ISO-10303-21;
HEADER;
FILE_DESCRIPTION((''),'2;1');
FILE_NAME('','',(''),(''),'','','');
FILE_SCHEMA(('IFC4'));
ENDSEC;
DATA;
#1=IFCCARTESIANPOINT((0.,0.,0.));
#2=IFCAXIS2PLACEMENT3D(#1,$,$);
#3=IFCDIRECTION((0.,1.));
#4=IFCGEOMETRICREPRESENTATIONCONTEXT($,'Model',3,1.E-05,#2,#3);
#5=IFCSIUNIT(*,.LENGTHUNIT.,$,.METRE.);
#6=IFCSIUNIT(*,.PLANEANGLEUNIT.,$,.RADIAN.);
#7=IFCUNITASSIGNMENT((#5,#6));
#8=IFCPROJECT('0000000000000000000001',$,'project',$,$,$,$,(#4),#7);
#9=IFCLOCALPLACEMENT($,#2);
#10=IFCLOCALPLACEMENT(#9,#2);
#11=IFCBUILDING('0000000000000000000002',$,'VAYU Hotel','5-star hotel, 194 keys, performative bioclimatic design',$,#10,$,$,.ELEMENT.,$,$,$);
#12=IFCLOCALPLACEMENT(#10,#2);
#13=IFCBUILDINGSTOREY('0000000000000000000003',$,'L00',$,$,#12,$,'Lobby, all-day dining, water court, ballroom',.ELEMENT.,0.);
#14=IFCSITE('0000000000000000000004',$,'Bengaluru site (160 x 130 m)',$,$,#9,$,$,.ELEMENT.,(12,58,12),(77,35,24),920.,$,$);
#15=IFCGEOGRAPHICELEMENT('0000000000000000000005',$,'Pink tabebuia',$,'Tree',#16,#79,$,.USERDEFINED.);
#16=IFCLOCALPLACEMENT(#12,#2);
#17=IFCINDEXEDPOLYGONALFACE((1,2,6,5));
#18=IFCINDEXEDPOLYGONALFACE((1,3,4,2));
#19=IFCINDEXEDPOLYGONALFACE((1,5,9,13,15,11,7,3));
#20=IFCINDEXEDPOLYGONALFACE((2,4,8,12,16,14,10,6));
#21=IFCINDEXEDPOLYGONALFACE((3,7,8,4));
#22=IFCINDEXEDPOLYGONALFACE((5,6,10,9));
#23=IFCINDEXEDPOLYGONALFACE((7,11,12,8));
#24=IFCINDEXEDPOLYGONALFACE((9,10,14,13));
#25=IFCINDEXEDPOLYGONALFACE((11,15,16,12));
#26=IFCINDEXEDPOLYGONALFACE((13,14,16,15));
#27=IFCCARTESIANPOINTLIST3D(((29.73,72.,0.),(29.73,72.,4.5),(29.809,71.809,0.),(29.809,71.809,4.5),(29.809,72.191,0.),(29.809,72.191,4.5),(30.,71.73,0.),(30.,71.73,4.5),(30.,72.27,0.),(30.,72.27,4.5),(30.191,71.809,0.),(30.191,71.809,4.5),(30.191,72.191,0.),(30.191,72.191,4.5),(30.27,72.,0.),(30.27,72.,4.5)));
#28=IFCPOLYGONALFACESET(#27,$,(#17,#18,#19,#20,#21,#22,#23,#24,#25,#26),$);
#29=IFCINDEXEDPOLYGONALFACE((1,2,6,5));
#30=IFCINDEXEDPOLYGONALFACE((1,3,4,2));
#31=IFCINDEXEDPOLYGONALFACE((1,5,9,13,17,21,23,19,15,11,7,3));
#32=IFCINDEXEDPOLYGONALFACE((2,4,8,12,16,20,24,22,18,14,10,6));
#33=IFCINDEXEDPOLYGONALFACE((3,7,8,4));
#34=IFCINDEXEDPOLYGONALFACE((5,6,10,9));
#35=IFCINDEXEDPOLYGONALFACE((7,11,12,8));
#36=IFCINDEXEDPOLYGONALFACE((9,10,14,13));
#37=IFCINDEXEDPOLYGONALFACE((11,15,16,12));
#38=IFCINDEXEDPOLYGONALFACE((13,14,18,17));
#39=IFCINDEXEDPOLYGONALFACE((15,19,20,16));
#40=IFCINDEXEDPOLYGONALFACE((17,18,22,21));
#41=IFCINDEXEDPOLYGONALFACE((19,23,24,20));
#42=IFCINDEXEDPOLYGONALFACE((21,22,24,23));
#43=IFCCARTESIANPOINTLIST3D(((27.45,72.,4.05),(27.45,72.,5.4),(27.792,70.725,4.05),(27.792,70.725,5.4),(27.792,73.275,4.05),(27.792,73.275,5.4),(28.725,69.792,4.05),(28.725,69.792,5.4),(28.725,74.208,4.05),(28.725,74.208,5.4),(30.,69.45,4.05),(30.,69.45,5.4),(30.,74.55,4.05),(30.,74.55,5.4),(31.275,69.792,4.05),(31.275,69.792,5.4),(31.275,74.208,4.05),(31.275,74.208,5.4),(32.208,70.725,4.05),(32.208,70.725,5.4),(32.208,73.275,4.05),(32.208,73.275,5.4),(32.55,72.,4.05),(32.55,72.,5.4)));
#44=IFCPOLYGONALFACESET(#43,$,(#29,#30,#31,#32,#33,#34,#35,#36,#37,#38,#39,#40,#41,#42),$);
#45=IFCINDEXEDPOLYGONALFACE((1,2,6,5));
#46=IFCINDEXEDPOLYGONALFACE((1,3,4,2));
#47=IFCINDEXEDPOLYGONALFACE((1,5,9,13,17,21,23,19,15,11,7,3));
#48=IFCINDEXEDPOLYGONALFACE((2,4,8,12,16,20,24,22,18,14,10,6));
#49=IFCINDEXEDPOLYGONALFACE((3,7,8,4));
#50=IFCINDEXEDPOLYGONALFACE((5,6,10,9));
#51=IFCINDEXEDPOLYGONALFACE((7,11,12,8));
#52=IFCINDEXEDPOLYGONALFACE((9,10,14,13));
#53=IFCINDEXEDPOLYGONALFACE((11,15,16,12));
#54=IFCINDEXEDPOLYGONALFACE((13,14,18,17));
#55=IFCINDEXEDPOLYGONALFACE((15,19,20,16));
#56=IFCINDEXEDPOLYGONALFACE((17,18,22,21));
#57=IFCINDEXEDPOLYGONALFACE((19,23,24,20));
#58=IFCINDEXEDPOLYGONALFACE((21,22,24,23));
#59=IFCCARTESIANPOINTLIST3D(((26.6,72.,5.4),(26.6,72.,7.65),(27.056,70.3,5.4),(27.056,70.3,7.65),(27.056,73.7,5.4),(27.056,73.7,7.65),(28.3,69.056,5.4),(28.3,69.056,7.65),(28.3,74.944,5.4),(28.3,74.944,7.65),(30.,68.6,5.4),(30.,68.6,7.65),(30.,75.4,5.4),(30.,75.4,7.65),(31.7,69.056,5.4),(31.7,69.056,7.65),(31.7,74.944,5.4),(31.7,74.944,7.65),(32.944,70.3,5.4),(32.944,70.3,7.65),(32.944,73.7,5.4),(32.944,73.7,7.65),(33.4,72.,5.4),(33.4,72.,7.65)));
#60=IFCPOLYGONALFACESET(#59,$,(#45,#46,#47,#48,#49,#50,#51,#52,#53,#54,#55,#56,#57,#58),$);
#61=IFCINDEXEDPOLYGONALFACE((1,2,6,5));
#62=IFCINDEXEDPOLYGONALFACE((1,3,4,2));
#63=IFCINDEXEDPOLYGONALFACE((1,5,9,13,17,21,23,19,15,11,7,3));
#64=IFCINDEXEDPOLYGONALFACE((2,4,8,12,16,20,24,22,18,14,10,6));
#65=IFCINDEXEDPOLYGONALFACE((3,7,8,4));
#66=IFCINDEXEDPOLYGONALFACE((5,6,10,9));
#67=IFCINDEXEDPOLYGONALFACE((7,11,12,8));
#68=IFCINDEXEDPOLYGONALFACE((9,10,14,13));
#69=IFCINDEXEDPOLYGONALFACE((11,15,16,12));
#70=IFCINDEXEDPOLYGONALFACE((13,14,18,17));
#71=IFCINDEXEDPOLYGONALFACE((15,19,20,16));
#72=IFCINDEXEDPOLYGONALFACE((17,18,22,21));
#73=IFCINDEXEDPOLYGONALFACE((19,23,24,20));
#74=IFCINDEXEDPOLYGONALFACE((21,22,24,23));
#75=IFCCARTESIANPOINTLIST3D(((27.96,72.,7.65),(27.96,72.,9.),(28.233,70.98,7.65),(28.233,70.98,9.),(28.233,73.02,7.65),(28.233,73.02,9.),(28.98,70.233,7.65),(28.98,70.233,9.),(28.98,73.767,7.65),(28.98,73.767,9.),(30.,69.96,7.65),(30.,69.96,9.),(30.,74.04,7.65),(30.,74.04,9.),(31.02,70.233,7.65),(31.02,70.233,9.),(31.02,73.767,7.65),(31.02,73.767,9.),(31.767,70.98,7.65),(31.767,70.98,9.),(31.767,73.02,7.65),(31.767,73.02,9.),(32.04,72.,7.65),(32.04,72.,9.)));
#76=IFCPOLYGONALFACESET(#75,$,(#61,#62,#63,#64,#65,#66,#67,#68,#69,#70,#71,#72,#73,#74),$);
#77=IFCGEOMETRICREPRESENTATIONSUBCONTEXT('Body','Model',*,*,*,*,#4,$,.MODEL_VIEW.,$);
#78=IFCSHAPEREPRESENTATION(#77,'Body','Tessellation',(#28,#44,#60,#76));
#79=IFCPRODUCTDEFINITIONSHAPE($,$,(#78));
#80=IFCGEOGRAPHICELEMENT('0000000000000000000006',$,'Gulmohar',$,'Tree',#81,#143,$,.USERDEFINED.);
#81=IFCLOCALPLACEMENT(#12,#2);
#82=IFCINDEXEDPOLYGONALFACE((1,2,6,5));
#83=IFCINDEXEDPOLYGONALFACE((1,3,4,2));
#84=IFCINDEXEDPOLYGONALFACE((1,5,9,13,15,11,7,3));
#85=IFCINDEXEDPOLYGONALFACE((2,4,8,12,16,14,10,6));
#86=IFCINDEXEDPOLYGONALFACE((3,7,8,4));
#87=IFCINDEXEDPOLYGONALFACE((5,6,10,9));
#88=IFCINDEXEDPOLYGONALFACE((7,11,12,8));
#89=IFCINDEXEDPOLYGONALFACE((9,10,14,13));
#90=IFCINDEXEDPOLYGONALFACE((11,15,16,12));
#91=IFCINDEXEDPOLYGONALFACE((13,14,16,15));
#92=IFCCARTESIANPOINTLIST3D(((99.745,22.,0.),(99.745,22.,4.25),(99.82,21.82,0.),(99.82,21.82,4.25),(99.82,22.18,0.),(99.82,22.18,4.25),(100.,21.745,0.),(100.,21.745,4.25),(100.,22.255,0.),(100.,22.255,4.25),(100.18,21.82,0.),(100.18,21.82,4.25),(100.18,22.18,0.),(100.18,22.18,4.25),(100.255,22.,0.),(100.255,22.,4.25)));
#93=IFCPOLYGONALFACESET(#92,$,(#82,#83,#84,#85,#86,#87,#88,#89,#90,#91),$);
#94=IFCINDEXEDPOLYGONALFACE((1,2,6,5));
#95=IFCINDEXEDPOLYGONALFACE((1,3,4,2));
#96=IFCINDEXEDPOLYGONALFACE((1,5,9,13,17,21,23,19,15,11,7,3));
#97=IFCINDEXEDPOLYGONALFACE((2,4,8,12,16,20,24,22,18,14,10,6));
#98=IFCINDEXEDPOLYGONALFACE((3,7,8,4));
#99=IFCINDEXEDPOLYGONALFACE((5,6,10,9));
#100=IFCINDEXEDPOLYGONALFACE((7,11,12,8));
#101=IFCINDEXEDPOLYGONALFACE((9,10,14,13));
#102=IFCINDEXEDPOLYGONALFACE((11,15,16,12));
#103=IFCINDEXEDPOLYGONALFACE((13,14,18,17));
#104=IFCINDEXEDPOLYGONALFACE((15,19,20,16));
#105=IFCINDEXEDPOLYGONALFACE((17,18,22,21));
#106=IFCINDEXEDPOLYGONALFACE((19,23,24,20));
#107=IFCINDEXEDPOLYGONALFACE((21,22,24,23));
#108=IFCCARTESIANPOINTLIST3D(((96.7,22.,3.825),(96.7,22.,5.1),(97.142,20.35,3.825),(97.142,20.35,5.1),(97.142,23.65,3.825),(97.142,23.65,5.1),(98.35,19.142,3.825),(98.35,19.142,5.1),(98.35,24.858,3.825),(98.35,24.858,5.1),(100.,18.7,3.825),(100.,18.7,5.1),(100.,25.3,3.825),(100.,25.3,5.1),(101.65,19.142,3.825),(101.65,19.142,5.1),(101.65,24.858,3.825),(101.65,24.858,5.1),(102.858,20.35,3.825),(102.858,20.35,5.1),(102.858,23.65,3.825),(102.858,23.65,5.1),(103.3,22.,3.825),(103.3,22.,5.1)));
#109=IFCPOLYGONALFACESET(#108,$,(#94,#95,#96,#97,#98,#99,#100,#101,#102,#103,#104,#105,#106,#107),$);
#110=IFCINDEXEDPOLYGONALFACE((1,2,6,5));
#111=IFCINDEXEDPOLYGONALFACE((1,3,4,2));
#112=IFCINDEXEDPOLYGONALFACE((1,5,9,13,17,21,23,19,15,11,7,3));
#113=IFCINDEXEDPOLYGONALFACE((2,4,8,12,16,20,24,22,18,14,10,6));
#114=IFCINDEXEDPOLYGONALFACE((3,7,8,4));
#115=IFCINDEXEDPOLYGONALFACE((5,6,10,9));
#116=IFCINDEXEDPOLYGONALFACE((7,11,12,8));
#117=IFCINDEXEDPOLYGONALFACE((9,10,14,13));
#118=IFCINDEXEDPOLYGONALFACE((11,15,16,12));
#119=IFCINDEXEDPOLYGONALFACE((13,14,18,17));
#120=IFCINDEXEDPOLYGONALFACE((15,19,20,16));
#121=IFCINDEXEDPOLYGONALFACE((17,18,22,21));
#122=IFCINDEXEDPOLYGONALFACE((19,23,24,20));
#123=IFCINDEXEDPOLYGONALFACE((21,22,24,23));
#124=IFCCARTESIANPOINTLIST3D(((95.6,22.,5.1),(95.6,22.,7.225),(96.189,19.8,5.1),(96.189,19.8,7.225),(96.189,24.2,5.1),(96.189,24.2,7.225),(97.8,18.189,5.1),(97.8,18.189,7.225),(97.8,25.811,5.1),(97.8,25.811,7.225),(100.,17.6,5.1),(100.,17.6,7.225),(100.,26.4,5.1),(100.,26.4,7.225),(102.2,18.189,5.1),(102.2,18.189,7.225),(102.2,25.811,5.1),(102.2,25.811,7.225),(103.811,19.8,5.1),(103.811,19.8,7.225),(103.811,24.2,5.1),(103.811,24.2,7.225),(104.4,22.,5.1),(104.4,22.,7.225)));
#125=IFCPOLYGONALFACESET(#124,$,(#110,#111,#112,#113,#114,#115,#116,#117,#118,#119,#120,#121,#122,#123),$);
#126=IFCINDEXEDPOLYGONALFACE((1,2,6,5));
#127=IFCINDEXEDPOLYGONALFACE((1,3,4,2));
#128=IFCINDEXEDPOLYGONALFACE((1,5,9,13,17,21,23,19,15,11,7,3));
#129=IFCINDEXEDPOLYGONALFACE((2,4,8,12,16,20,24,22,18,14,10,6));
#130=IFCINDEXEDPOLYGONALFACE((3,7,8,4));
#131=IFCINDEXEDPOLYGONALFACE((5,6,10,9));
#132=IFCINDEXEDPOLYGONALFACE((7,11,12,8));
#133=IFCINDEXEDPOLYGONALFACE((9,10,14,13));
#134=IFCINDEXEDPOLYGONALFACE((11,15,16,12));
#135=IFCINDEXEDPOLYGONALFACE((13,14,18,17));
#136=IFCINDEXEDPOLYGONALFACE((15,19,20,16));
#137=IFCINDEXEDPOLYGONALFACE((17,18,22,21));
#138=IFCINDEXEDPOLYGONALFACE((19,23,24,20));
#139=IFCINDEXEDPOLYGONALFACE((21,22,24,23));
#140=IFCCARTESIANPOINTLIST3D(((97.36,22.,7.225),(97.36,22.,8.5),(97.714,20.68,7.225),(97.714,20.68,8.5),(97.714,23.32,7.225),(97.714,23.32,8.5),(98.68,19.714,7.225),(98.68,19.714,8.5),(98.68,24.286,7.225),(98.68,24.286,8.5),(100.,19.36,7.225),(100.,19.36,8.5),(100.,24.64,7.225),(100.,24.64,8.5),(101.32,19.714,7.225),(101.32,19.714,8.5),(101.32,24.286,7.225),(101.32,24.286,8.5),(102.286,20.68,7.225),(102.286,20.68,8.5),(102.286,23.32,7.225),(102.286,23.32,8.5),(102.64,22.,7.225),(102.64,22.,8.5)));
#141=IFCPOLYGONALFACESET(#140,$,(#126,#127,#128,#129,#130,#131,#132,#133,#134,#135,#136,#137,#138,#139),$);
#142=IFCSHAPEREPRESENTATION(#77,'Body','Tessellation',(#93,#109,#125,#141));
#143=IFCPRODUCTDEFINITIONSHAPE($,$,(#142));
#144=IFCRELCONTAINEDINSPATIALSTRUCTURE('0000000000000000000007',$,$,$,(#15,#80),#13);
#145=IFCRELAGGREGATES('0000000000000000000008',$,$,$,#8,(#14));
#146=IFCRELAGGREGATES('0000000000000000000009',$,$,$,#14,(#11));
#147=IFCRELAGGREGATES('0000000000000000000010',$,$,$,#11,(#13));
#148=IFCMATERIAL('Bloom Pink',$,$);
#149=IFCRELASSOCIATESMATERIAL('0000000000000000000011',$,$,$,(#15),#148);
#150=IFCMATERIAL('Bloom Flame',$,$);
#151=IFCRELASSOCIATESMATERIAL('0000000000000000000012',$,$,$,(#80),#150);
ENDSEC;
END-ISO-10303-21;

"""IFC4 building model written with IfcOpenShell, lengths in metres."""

from ifc_helpers import new_model, si_unit, direction, frame, origin, place, context, subcontext, project, spatial, polyline, outline, extrude, material, element, save


model = new_model("IFC4")

# Units and contexts
model_context = context("Model", 3, precision=1e-05, world=origin(), true_north=direction((0.0, 1.0)))
body_context = subcontext(model_context, "Body", "Model", "MODEL_VIEW")
ifc_project = project(units=[si_unit("LENGTHUNIT", "METRE"), si_unit("PLANEANGLEUNIT", "RADIAN")], contexts=[model_context])

# Site, building, storey
site_placement = place(None, origin())
site = spatial("IfcSite", under=ifc_project, at=site_placement, Name="Bengaluru site (160 x 130 m)", CompositionType="ELEMENT", RefLatitude=(12, 58, 12), RefLongitude=(77, 35, 24), RefElevation=920.0)
building_placement = place(site_placement, origin())
building = spatial("IfcBuilding", under=site, at=building_placement, Name="VAYU Hotel", Description="5-star hotel, 194 keys, performative bioclimatic design", CompositionType="ELEMENT")
storey_placement = place(building_placement, origin())
storey = spatial("IfcBuildingStorey", under=building, at=storey_placement, Name="L00", LongName="Lobby, all-day dining, water court, ballroom", CompositionType="ELEMENT", Elevation=0.0)

# Geographic elements
ifc_material_1 = material(Name="Bloom Pink")
ifc_material_2 = material(Name="Bloom Flame")
geographic_element_1_placement = place(storey_placement, origin())
element("IfcGeographicElement", 1, at=geographic_element_1_placement, inside=storey, material=ifc_material_1, Name="Pink tabebuia", ObjectType="Tree", PredefinedType="USERDEFINED", context=body_context, shape_type="SweptSolid", body=[
    extrude(outline(polyline([(30.27, 72.0), (30.191, 72.191), (30.0, 72.27), (29.809, 72.191), (29.73, 72.0), (29.809, 71.809), (30.0, 71.73), (30.191, 71.809), (30.27, 72.0)])), origin(), (0.0, 0.0, 1.0), 4.5),
    extrude(outline(polyline([(32.55, 72.0), (32.208, 73.275), (31.275, 74.208), (30.0, 74.55), (28.725, 74.208), (27.792, 73.275), (27.45, 72.0), (27.792, 70.725), (28.725, 69.792), (30.0, 69.45), (31.275, 69.792), (32.208, 70.725), (32.55, 72.0)])), frame((0.0, 0.0, 4.05)), (0.0, 0.0, 1.0), 1.35),
    extrude(outline(polyline([(33.4, 72.0), (32.944, 73.7), (31.7, 74.944), (30.0, 75.4), (28.3, 74.944), (27.056, 73.7), (26.6, 72.0), (27.056, 70.3), (28.3, 69.056), (30.0, 68.6), (31.7, 69.056), (32.944, 70.3), (33.4, 72.0)])), frame((0.0, 0.0, 5.4)), (0.0, 0.0, 1.0), 2.25),
    extrude(outline(polyline([(32.04, 72.0), (31.767, 73.02), (31.02, 73.767), (30.0, 74.04), (28.98, 73.767), (28.233, 73.02), (27.96, 72.0), (28.233, 70.98), (28.98, 70.233), (30.0, 69.96), (31.02, 70.233), (31.767, 70.98), (32.04, 72.0)])), frame((0.0, 0.0, 7.65)), (0.0, 0.0, 1.0), 1.35),
])
geographic_element_2_placement = place(storey_placement, origin())
element("IfcGeographicElement", 2, at=geographic_element_2_placement, inside=storey, material=ifc_material_2, Name="Gulmohar", ObjectType="Tree", PredefinedType="USERDEFINED", context=body_context, shape_type="SweptSolid", body=[
    extrude(outline(polyline([(100.255, 22.0), (100.18, 22.18), (100.0, 22.255), (99.82, 22.18), (99.745, 22.0), (99.82, 21.82), (100.0, 21.745), (100.18, 21.82), (100.255, 22.0)])), origin(), (0.0, 0.0, 1.0), 4.25),
    extrude(outline(polyline([(103.3, 22.0), (102.858, 23.65), (101.65, 24.858), (100.0, 25.3), (98.35, 24.858), (97.142, 23.65), (96.7, 22.0), (97.142, 20.35), (98.35, 19.142), (100.0, 18.7), (101.65, 19.142), (102.858, 20.35), (103.3, 22.0)])), frame((0.0, 0.0, 3.825)), (0.0, 0.0, 1.0), 1.275),
    extrude(outline(polyline([(104.4, 22.0), (103.811, 24.2), (102.2, 25.811), (100.0, 26.4), (97.8, 25.811), (96.189, 24.2), (95.6, 22.0), (96.189, 19.8), (97.8, 18.189), (100.0, 17.6), (102.2, 18.189), (103.811, 19.8), (104.4, 22.0)])), frame((0.0, 0.0, 5.1)), (0.0, 0.0, 1.0), 2.125),
    extrude(outline(polyline([(102.64, 22.0), (102.286, 23.32), (101.32, 24.286), (100.0, 24.64), (98.68, 24.286), (97.714, 23.32), (97.36, 22.0), (97.714, 20.68), (98.68, 19.714), (100.0, 19.36), (101.32, 19.714), (102.286, 20.68), (102.64, 22.0)])), frame((0.0, 0.0, 7.225)), (0.0, 0.0, 1.0), 1.275),
])

save(model, "model.ifc")
